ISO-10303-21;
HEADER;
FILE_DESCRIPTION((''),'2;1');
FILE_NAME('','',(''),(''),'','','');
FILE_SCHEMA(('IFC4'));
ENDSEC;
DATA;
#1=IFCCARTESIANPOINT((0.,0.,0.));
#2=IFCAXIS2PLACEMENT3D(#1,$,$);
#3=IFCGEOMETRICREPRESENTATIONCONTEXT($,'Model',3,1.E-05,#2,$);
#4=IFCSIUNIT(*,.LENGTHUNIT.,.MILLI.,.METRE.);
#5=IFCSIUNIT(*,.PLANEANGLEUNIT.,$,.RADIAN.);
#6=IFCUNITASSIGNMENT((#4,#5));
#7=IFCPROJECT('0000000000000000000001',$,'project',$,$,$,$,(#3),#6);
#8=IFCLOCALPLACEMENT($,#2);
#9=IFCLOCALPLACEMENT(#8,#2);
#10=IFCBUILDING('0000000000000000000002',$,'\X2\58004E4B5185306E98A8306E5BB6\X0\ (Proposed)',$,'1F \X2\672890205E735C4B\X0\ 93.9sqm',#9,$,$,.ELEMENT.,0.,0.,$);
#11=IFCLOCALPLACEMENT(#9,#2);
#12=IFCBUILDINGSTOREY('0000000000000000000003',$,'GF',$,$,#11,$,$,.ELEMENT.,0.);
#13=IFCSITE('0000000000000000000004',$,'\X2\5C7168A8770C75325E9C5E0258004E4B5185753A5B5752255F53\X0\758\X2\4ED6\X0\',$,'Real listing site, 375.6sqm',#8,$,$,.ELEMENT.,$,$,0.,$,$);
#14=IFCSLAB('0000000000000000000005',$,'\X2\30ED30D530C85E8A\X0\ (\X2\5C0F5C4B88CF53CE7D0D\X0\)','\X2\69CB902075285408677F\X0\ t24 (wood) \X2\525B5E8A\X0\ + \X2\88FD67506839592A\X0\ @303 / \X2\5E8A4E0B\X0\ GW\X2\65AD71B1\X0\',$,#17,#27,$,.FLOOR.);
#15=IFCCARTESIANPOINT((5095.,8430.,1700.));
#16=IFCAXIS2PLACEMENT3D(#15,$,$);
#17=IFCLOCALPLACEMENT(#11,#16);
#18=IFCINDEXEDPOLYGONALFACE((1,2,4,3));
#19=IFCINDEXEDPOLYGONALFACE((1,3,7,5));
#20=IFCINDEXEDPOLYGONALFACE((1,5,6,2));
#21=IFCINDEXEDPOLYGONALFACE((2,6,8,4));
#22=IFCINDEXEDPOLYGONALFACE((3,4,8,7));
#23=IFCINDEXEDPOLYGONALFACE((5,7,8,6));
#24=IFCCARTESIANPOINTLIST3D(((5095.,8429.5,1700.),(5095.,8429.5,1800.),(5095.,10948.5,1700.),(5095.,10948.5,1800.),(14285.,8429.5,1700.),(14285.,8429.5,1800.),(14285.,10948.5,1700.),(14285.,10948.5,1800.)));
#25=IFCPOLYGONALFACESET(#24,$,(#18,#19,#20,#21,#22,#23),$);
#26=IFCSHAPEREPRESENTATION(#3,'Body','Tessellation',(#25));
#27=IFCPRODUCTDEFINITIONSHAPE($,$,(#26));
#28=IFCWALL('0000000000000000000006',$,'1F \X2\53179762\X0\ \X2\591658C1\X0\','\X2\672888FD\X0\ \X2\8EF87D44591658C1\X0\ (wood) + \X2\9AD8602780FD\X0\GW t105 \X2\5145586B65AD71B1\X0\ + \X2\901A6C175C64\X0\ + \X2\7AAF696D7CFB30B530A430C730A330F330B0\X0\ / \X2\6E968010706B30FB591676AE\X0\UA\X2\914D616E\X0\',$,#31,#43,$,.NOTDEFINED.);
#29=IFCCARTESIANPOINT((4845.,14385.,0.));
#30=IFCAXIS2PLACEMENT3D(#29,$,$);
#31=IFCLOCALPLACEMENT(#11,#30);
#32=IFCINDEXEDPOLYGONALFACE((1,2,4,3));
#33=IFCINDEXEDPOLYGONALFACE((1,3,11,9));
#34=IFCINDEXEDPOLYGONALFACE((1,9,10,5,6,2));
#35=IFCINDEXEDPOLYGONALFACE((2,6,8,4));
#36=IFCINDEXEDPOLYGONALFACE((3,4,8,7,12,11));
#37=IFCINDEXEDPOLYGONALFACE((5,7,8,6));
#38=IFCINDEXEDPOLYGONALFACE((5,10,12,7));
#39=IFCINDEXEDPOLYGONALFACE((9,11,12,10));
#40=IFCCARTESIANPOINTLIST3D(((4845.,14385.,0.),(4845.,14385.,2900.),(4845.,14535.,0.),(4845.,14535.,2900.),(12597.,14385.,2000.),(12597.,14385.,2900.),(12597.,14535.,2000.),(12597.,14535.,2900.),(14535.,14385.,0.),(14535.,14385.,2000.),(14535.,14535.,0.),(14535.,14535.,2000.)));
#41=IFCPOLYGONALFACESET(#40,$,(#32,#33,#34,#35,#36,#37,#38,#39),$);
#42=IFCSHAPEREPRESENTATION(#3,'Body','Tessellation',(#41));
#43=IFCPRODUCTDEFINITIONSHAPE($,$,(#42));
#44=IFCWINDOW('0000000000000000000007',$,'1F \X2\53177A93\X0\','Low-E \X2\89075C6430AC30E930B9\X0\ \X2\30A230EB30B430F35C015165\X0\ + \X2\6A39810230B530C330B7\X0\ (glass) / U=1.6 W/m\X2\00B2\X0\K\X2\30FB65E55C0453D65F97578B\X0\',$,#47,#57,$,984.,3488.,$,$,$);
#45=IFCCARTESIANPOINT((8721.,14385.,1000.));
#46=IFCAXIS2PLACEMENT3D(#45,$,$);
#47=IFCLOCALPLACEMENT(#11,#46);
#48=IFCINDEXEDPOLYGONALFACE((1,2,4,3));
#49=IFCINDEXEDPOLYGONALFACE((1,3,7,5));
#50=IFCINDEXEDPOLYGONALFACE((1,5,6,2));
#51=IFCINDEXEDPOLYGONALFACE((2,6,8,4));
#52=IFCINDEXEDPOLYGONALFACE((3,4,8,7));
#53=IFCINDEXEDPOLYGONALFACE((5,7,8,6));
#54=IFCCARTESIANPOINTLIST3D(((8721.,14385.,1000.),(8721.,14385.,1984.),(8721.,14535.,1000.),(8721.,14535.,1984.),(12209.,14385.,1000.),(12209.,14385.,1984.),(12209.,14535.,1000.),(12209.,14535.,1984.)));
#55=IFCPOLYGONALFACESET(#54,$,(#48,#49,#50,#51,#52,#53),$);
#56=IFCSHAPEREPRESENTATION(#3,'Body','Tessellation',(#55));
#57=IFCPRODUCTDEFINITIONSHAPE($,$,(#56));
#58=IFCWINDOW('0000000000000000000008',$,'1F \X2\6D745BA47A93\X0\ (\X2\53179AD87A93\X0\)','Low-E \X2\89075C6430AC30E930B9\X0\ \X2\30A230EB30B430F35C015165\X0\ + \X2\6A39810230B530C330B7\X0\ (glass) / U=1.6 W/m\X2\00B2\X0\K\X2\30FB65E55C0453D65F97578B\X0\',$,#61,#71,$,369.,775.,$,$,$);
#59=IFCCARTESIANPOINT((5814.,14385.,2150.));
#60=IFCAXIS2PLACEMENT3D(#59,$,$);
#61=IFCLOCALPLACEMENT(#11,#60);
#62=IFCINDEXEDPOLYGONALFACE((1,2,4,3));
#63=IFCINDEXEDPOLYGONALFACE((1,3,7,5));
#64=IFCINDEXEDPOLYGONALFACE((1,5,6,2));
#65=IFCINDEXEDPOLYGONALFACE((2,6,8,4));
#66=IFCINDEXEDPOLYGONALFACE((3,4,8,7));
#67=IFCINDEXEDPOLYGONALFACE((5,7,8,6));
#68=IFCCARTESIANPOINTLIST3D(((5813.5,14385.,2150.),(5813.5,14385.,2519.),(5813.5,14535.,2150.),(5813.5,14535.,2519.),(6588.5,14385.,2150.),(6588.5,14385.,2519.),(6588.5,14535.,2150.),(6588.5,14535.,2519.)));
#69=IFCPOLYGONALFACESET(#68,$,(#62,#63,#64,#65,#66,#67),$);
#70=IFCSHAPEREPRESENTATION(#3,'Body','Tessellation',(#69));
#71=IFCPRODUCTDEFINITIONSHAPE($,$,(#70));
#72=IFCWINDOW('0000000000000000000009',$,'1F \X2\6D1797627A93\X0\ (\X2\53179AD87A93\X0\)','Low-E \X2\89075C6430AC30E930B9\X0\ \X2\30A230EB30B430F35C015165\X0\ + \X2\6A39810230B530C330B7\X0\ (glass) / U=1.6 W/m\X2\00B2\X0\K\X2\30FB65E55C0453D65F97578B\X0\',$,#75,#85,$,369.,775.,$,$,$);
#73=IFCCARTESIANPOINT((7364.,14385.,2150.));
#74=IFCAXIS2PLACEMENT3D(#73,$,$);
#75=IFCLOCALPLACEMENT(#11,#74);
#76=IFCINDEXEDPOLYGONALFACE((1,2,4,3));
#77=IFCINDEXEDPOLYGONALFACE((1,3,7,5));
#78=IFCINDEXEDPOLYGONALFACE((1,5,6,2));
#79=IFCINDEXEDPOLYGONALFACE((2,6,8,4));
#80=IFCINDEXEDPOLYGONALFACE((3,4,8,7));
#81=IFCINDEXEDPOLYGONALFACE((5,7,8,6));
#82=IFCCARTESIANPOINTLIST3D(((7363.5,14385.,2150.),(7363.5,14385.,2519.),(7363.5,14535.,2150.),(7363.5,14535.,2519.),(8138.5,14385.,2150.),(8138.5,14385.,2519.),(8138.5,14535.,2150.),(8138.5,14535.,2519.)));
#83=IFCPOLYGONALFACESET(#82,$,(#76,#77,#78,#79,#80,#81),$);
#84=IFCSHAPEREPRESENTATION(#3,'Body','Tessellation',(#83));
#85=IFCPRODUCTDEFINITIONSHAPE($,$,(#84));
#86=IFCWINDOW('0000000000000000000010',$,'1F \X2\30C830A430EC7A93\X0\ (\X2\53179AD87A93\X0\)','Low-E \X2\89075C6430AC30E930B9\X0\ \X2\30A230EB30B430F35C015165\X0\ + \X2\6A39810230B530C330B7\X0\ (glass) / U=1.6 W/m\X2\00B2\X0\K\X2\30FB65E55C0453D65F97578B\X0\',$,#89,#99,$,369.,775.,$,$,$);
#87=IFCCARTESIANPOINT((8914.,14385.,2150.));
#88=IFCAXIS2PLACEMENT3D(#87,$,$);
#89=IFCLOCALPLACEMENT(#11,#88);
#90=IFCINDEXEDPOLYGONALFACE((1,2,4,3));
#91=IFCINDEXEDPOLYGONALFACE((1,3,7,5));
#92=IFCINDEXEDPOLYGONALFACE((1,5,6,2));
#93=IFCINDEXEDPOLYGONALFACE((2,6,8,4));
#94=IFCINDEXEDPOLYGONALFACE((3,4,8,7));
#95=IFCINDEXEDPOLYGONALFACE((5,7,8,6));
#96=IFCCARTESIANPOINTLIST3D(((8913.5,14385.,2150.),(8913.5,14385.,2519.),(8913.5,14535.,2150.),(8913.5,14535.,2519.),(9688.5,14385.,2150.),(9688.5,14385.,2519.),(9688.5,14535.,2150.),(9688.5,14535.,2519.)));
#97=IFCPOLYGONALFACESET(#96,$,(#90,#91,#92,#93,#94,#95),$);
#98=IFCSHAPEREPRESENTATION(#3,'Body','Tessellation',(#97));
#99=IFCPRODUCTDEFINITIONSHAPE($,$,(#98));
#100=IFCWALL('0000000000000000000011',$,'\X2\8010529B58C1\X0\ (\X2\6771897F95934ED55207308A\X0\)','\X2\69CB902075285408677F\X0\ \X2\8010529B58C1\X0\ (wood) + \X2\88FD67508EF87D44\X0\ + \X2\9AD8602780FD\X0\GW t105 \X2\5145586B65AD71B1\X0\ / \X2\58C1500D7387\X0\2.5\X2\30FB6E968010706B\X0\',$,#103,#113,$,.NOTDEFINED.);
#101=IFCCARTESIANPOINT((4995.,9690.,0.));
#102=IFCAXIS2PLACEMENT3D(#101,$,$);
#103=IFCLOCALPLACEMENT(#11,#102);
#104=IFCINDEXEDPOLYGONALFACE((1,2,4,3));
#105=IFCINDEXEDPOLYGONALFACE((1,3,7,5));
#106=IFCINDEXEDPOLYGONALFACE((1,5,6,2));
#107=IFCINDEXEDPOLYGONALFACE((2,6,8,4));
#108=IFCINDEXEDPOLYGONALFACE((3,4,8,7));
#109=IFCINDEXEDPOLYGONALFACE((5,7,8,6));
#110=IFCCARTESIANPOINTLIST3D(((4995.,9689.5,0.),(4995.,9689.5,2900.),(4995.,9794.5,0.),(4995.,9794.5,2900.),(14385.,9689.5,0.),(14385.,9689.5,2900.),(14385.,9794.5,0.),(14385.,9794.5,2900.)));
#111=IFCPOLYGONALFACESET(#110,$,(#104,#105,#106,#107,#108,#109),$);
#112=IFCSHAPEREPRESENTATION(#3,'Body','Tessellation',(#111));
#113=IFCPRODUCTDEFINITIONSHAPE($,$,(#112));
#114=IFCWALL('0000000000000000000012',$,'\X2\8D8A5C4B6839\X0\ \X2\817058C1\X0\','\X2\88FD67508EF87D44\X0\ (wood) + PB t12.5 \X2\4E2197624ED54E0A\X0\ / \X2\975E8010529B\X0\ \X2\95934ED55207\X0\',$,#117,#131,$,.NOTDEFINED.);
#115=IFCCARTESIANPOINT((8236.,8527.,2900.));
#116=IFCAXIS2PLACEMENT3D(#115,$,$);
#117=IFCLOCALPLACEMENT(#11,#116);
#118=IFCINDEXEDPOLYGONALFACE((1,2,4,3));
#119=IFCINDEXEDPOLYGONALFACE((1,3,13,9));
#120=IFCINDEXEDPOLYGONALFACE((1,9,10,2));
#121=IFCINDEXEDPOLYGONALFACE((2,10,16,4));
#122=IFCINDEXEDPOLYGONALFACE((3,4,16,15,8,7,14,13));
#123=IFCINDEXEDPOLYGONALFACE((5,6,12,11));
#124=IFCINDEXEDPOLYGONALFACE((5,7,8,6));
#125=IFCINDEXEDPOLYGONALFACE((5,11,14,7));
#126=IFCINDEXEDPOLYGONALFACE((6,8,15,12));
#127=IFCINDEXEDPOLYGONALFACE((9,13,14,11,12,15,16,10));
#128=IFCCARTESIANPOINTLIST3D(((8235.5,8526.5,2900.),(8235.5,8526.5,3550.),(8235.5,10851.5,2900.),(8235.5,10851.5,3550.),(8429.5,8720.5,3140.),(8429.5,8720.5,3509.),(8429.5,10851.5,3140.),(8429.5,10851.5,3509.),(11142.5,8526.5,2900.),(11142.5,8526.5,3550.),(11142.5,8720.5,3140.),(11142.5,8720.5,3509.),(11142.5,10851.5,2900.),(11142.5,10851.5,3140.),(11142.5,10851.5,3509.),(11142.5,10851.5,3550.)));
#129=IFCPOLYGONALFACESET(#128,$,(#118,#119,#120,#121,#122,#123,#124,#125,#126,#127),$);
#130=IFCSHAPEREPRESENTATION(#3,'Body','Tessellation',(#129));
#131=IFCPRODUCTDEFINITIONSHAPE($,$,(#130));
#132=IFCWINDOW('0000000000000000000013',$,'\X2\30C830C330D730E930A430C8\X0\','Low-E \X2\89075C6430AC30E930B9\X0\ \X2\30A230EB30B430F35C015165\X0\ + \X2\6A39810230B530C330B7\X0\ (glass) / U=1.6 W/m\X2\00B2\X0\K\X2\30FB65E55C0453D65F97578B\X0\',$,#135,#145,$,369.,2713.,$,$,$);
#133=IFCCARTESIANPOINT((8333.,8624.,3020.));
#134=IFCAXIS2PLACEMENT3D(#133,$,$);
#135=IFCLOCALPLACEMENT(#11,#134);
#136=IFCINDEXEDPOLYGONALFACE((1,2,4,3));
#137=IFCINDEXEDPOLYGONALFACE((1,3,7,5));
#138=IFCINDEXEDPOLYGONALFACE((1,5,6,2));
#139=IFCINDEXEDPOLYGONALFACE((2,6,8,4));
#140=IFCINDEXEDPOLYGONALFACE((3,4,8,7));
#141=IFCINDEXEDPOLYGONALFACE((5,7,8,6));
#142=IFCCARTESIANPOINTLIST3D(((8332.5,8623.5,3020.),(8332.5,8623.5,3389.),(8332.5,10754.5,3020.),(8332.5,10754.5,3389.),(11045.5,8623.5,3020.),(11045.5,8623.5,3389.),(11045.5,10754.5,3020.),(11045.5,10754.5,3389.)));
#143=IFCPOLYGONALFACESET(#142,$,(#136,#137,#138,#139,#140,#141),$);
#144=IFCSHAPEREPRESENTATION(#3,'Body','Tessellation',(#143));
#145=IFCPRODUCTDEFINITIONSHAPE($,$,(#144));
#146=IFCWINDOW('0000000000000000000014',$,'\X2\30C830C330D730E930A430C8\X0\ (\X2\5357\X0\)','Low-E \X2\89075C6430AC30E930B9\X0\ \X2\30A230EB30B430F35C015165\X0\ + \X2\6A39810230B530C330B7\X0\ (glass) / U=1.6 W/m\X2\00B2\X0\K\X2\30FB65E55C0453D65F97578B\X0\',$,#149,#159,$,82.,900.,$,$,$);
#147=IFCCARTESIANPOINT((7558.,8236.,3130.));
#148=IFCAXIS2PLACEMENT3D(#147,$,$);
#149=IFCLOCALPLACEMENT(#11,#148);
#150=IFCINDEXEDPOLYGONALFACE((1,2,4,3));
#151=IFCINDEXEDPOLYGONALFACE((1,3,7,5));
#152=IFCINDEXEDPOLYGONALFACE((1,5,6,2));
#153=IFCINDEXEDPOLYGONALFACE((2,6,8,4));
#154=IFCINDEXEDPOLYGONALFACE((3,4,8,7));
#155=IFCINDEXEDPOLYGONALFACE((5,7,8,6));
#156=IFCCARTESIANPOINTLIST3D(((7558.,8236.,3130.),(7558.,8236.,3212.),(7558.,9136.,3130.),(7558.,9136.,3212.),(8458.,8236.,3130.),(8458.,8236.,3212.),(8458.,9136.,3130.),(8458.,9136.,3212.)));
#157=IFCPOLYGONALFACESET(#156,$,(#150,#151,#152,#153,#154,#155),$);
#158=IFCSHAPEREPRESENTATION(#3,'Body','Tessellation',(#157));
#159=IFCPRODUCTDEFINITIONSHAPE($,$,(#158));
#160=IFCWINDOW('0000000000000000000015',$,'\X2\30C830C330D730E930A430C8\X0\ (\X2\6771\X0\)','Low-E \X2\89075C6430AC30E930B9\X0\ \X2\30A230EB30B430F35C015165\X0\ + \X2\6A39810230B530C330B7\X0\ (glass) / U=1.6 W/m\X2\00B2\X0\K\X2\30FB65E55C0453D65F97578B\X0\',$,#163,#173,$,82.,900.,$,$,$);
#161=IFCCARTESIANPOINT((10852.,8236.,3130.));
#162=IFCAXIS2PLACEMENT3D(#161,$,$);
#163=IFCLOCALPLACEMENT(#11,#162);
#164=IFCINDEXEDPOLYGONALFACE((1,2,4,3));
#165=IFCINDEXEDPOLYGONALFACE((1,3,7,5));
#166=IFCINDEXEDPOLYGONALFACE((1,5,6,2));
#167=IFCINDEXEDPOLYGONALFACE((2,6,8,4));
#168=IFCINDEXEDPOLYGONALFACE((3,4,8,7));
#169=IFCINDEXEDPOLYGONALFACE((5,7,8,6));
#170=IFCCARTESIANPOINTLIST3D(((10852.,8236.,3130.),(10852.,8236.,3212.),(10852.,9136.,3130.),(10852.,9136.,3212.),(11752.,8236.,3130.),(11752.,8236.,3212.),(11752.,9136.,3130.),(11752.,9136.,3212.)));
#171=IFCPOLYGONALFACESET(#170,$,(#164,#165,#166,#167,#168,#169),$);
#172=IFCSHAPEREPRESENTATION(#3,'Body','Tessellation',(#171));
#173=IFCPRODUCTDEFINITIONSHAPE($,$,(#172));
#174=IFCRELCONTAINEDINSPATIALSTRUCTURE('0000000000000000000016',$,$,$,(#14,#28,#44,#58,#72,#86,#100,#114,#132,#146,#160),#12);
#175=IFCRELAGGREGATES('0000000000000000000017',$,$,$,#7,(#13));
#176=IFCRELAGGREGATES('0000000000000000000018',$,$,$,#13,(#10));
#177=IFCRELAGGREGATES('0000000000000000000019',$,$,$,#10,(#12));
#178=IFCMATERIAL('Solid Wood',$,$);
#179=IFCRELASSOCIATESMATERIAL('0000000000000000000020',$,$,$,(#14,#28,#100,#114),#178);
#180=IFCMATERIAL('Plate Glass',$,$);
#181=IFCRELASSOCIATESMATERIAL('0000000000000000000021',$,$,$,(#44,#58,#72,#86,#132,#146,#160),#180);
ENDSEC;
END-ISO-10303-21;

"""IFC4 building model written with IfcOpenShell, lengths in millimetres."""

from ifc_helpers import new_model, si_unit, frame, frame_2d, origin, place, context, project, spatial, rectangle, extrude, material, element, fill, save


model = new_model("IFC4")

# Units and contexts
model_context = context("Model", 3, precision=1e-05, world=origin())
ifc_project = project(units=[si_unit("LENGTHUNIT", "METRE", prefix="MILLI"), si_unit("PLANEANGLEUNIT", "RADIAN")], contexts=[model_context])

# Site, building, storey
site_placement = place(None, origin())
site = spatial("IfcSite", under=ifc_project, at=site_placement, Name="山梨県甲府市堀之内町字別当758他", ObjectType="Real listing site, 375.6sqm", CompositionType="ELEMENT", RefElevation=0.0)
building_placement = place(site_placement, origin())
building = spatial("IfcBuilding", under=site, at=building_placement, Name="堀之内の風の家 (Proposed)", ObjectType="1F 木造平屋 93.9sqm", CompositionType="ELEMENT", ElevationOfRefHeight=0.0, ElevationOfTerrain=0.0)
storey_placement = place(building_placement, origin())
storey = spatial("IfcBuildingStorey", under=building, at=storey_placement, Name="GF", CompositionType="ELEMENT", Elevation=0.0)

# Slab
ifc_material_1 = material(Name="Solid Wood")
slab_placement = place(storey_placement, frame((5095.0, 8430.0, 1700.0)))
element("IfcSlab", 1, at=slab_placement, inside=storey, material=ifc_material_1, Name="ロフト床 (小屋裏収納)", Description="構造用合板 t24 (wood) 剛床 + 製材根太 @303 / 床下 GW断熱", PredefinedType="FLOOR", context=model_context, shape_type="SweptSolid", body=[
    extrude(rectangle(XDim=9190.0, YDim=2519.0, at=frame_2d((4595.0, 1259.0))), frame((5095.0, 8430.0, 1700.0)), (0.0, 0.0, 1.0), 100.0),
])

# Wall, openings, windows
wall_1_placement = place(storey_placement, frame((4845.0, 14385.0, 0.0)))
wall_1 = element("IfcWall", 2, at=wall_1_placement, inside=storey, material=ifc_material_1, Name="1F 北面 外壁", Description="木製 軸組外壁 (wood) + 高性能GW t105 充填断熱 + 通気層 + 窯業系サイディング / 準耐火・外皮UA配慮", PredefinedType="NOTDEFINED", context=model_context, shape_type="SweptSolid", body=[
    extrude(rectangle(XDim=9690.0, YDim=150.0, at=frame_2d((4845.0, 75.0))), frame((4845.0, 14385.0, 0.0)), (0.0, 0.0, 1.0), 2900.0),
])
opening_1_placement = place(storey_placement, frame((8721.0, 14385.0, 1000.0)))
opening_1 = element("IfcOpeningElement", 3, at=opening_1_placement, cuts=wall_1, PredefinedType="NOTDEFINED", context=model_context, shape_type="SweptSolid", body=[
    extrude(rectangle(XDim=3488.0, YDim=150.0, at=frame_2d((1744.0, 75.0))), frame((8721.0, 14385.0, 1000.0)), (0.0, 0.0, 1.0), 984.0),
])
opening_2_placement = place(storey_placement, frame((5814.0, 14385.0, 2150.0)))
opening_2 = element("IfcOpeningElement", 4, at=opening_2_placement, cuts=wall_1, PredefinedType="NOTDEFINED", context=model_context, shape_type="SweptSolid", body=[
    extrude(rectangle(XDim=775.0, YDim=150.0, at=frame_2d((387.0, 75.0))), frame((5814.0, 14385.0, 2150.0)), (0.0, 0.0, 1.0), 369.0),
])
opening_3_placement = place(storey_placement, frame((7364.0, 14385.0, 2150.0)))
opening_3 = element("IfcOpeningElement", 5, at=opening_3_placement, cuts=wall_1, PredefinedType="NOTDEFINED", context=model_context, shape_type="SweptSolid", body=[
    extrude(rectangle(XDim=775.0, YDim=150.0, at=frame_2d((387.0, 75.0))), frame((7364.0, 14385.0, 2150.0)), (0.0, 0.0, 1.0), 369.0),
])
opening_4_placement = place(storey_placement, frame((8914.0, 14385.0, 2150.0)))
opening_4 = element("IfcOpeningElement", 6, at=opening_4_placement, cuts=wall_1, PredefinedType="NOTDEFINED", context=model_context, shape_type="SweptSolid", body=[
    extrude(rectangle(XDim=775.0, YDim=150.0, at=frame_2d((387.0, 75.0))), frame((8914.0, 14385.0, 2150.0)), (0.0, 0.0, 1.0), 369.0),
])
ifc_material_2 = material(Name="Plate Glass")
window_1_placement = place(storey_placement, frame((8721.0, 14385.0, 1000.0)))
window_1 = element("IfcWindow", 7, at=window_1_placement, inside=storey, material=ifc_material_2, Name="1F 北窓", Description="Low-E 複層ガラス アルゴン封入 + 樹脂サッシ (glass) / U=1.6 W/m²K・日射取得型", OverallHeight=984.0, OverallWidth=3488.0, context=model_context, shape_type="SweptSolid", body=[
    extrude(rectangle(XDim=3488.0, YDim=150.0, at=frame_2d((1744.0, 75.0))), frame((8721.0, 14385.0, 1000.0)), (0.0, 0.0, 1.0), 984.0),
])
fill(opening_1, window_1)
window_2_placement = place(storey_placement, frame((5814.0, 14385.0, 2150.0)))
window_2 = element("IfcWindow", 8, at=window_2_placement, inside=storey, material=ifc_material_2, Name="1F 浴室窓 (北高窓)", Description="Low-E 複層ガラス アルゴン封入 + 樹脂サッシ (glass) / U=1.6 W/m²K・日射取得型", OverallHeight=369.0, OverallWidth=775.0, context=model_context, shape_type="SweptSolid", body=[
    extrude(rectangle(XDim=775.0, YDim=150.0, at=frame_2d((387.0, 75.0))), frame((5814.0, 14385.0, 2150.0)), (0.0, 0.0, 1.0), 369.0),
])
fill(opening_2, window_2)
window_3_placement = place(storey_placement, frame((7364.0, 14385.0, 2150.0)))
window_3 = element("IfcWindow", 9, at=window_3_placement, inside=storey, material=ifc_material_2, Name="1F 洗面窓 (北高窓)", Description="Low-E 複層ガラス アルゴン封入 + 樹脂サッシ (glass) / U=1.6 W/m²K・日射取得型", OverallHeight=369.0, OverallWidth=775.0, context=model_context, shape_type="SweptSolid", body=[
    extrude(rectangle(XDim=775.0, YDim=150.0, at=frame_2d((387.0, 75.0))), frame((7364.0, 14385.0, 2150.0)), (0.0, 0.0, 1.0), 369.0),
])
fill(opening_3, window_3)
window_4_placement = place(storey_placement, frame((8914.0, 14385.0, 2150.0)))
window_4 = element("IfcWindow", 10, at=window_4_placement, inside=storey, material=ifc_material_2, Name="1F トイレ窓 (北高窓)", Description="Low-E 複層ガラス アルゴン封入 + 樹脂サッシ (glass) / U=1.6 W/m²K・日射取得型", OverallHeight=369.0, OverallWidth=775.0, context=model_context, shape_type="SweptSolid", body=[
    extrude(rectangle(XDim=775.0, YDim=150.0, at=frame_2d((387.0, 75.0))), frame((8914.0, 14385.0, 2150.0)), (0.0, 0.0, 1.0), 369.0),
])
fill(opening_4, window_4)

# Wall
wall_2_placement = place(storey_placement, frame((4995.0, 9690.0, 0.0)))
element("IfcWall", 11, at=wall_2_placement, inside=storey, material=ifc_material_1, Name="耐力壁 (東西間仕切り)", Description="構造用合板 耐力壁 (wood) + 製材軸組 + 高性能GW t105 充填断熱 / 壁倍率2.5・準耐火", PredefinedType="NOTDEFINED", context=model_context, shape_type="SweptSolid", body=[
    extrude(rectangle(XDim=9390.0, YDim=105.0, at=frame_2d((4695.0, 52.0))), frame((4995.0, 9690.0, 0.0)), (0.0, 0.0, 1.0), 2900.0),
])

# Wall, openings, windows
wall_3_placement = place(storey_placement, frame((8236.0, 8527.0, 2900.0)))
wall_3 = element("IfcWall", 12, at=wall_3_placement, inside=storey, material=ifc_material_1, Name="越屋根 腰壁", Description="製材軸組 (wood) + PB t12.5 両面仕上 / 非耐力 間仕切", PredefinedType="NOTDEFINED", context=model_context, shape_type="SweptSolid", body=[
    extrude(rectangle(XDim=2907.0, YDim=2325.0, at=frame_2d((1453.0, 1162.0))), frame((8236.0, 8527.0, 2900.0)), (0.0, 0.0, 1.0), 650.0),
])
opening_5_placement = place(storey_placement, frame((8333.0, 8624.0, 3020.0)))
opening_5 = element("IfcOpeningElement", 13, at=opening_5_placement, cuts=wall_3, PredefinedType="NOTDEFINED", context=model_context, shape_type="SweptSolid", body=[
    extrude(rectangle(XDim=2713.0, YDim=2131.0, at=frame_2d((1356.0, 1065.0))), frame((8333.0, 8624.0, 3020.0)), (0.0, 0.0, 1.0), 369.0),
])
opening_6_placement = place(storey_placement, frame((7558.0, 8236.0, 3130.0)))
opening_6 = element("IfcOpeningElement", 14, at=opening_6_placement, cuts=wall_3, PredefinedType="NOTDEFINED", context=model_context, shape_type="SweptSolid", body=[
    extrude(rectangle(XDim=900.0, YDim=900.0, at=frame_2d((450.0, 450.0))), frame((7558.0, 8236.0, 3130.0)), (0.0, 0.0, 1.0), 82.0),
])
opening_7_placement = place(storey_placement, frame((10852.0, 8236.0, 3130.0)))
opening_7 = element("IfcOpeningElement", 15, at=opening_7_placement, cuts=wall_3, PredefinedType="NOTDEFINED", context=model_context, shape_type="SweptSolid", body=[
    extrude(rectangle(XDim=900.0, YDim=900.0, at=frame_2d((450.0, 450.0))), frame((10852.0, 8236.0, 3130.0)), (0.0, 0.0, 1.0), 82.0),
])
window_5_placement = place(storey_placement, frame((8333.0, 8624.0, 3020.0)))
window_5 = element("IfcWindow", 16, at=window_5_placement, inside=storey, material=ifc_material_2, Name="トップライト", Description="Low-E 複層ガラス アルゴン封入 + 樹脂サッシ (glass) / U=1.6 W/m²K・日射取得型", OverallHeight=369.0, OverallWidth=2713.0, context=model_context, shape_type="SweptSolid", body=[
    extrude(rectangle(XDim=2713.0, YDim=2131.0, at=frame_2d((1356.0, 1065.0))), frame((8333.0, 8624.0, 3020.0)), (0.0, 0.0, 1.0), 369.0),
])
fill(opening_5, window_5)
window_6_placement = place(storey_placement, frame((7558.0, 8236.0, 3130.0)))
window_6 = element("IfcWindow", 17, at=window_6_placement, inside=storey, material=ifc_material_2, Name="トップライト (南)", Description="Low-E 複層ガラス アルゴン封入 + 樹脂サッシ (glass) / U=1.6 W/m²K・日射取得型", OverallHeight=82.0, OverallWidth=900.0, context=model_context, shape_type="SweptSolid", body=[
    extrude(rectangle(XDim=900.0, YDim=900.0, at=frame_2d((450.0, 450.0))), frame((7558.0, 8236.0, 3130.0)), (0.0, 0.0, 1.0), 82.0),
])
fill(opening_6, window_6)
window_7_placement = place(storey_placement, frame((10852.0, 8236.0, 3130.0)))
window_7 = element("IfcWindow", 18, at=window_7_placement, inside=storey, material=ifc_material_2, Name="トップライト (東)", Description="Low-E 複層ガラス アルゴン封入 + 樹脂サッシ (glass) / U=1.6 W/m²K・日射取得型", OverallHeight=82.0, OverallWidth=900.0, context=model_context, shape_type="SweptSolid", body=[
    extrude(rectangle(XDim=900.0, YDim=900.0, at=frame_2d((450.0, 450.0))), frame((10852.0, 8236.0, 3130.0)), (0.0, 0.0, 1.0), 82.0),
])
fill(opening_7, window_7)

save(model, "model.ifc")
